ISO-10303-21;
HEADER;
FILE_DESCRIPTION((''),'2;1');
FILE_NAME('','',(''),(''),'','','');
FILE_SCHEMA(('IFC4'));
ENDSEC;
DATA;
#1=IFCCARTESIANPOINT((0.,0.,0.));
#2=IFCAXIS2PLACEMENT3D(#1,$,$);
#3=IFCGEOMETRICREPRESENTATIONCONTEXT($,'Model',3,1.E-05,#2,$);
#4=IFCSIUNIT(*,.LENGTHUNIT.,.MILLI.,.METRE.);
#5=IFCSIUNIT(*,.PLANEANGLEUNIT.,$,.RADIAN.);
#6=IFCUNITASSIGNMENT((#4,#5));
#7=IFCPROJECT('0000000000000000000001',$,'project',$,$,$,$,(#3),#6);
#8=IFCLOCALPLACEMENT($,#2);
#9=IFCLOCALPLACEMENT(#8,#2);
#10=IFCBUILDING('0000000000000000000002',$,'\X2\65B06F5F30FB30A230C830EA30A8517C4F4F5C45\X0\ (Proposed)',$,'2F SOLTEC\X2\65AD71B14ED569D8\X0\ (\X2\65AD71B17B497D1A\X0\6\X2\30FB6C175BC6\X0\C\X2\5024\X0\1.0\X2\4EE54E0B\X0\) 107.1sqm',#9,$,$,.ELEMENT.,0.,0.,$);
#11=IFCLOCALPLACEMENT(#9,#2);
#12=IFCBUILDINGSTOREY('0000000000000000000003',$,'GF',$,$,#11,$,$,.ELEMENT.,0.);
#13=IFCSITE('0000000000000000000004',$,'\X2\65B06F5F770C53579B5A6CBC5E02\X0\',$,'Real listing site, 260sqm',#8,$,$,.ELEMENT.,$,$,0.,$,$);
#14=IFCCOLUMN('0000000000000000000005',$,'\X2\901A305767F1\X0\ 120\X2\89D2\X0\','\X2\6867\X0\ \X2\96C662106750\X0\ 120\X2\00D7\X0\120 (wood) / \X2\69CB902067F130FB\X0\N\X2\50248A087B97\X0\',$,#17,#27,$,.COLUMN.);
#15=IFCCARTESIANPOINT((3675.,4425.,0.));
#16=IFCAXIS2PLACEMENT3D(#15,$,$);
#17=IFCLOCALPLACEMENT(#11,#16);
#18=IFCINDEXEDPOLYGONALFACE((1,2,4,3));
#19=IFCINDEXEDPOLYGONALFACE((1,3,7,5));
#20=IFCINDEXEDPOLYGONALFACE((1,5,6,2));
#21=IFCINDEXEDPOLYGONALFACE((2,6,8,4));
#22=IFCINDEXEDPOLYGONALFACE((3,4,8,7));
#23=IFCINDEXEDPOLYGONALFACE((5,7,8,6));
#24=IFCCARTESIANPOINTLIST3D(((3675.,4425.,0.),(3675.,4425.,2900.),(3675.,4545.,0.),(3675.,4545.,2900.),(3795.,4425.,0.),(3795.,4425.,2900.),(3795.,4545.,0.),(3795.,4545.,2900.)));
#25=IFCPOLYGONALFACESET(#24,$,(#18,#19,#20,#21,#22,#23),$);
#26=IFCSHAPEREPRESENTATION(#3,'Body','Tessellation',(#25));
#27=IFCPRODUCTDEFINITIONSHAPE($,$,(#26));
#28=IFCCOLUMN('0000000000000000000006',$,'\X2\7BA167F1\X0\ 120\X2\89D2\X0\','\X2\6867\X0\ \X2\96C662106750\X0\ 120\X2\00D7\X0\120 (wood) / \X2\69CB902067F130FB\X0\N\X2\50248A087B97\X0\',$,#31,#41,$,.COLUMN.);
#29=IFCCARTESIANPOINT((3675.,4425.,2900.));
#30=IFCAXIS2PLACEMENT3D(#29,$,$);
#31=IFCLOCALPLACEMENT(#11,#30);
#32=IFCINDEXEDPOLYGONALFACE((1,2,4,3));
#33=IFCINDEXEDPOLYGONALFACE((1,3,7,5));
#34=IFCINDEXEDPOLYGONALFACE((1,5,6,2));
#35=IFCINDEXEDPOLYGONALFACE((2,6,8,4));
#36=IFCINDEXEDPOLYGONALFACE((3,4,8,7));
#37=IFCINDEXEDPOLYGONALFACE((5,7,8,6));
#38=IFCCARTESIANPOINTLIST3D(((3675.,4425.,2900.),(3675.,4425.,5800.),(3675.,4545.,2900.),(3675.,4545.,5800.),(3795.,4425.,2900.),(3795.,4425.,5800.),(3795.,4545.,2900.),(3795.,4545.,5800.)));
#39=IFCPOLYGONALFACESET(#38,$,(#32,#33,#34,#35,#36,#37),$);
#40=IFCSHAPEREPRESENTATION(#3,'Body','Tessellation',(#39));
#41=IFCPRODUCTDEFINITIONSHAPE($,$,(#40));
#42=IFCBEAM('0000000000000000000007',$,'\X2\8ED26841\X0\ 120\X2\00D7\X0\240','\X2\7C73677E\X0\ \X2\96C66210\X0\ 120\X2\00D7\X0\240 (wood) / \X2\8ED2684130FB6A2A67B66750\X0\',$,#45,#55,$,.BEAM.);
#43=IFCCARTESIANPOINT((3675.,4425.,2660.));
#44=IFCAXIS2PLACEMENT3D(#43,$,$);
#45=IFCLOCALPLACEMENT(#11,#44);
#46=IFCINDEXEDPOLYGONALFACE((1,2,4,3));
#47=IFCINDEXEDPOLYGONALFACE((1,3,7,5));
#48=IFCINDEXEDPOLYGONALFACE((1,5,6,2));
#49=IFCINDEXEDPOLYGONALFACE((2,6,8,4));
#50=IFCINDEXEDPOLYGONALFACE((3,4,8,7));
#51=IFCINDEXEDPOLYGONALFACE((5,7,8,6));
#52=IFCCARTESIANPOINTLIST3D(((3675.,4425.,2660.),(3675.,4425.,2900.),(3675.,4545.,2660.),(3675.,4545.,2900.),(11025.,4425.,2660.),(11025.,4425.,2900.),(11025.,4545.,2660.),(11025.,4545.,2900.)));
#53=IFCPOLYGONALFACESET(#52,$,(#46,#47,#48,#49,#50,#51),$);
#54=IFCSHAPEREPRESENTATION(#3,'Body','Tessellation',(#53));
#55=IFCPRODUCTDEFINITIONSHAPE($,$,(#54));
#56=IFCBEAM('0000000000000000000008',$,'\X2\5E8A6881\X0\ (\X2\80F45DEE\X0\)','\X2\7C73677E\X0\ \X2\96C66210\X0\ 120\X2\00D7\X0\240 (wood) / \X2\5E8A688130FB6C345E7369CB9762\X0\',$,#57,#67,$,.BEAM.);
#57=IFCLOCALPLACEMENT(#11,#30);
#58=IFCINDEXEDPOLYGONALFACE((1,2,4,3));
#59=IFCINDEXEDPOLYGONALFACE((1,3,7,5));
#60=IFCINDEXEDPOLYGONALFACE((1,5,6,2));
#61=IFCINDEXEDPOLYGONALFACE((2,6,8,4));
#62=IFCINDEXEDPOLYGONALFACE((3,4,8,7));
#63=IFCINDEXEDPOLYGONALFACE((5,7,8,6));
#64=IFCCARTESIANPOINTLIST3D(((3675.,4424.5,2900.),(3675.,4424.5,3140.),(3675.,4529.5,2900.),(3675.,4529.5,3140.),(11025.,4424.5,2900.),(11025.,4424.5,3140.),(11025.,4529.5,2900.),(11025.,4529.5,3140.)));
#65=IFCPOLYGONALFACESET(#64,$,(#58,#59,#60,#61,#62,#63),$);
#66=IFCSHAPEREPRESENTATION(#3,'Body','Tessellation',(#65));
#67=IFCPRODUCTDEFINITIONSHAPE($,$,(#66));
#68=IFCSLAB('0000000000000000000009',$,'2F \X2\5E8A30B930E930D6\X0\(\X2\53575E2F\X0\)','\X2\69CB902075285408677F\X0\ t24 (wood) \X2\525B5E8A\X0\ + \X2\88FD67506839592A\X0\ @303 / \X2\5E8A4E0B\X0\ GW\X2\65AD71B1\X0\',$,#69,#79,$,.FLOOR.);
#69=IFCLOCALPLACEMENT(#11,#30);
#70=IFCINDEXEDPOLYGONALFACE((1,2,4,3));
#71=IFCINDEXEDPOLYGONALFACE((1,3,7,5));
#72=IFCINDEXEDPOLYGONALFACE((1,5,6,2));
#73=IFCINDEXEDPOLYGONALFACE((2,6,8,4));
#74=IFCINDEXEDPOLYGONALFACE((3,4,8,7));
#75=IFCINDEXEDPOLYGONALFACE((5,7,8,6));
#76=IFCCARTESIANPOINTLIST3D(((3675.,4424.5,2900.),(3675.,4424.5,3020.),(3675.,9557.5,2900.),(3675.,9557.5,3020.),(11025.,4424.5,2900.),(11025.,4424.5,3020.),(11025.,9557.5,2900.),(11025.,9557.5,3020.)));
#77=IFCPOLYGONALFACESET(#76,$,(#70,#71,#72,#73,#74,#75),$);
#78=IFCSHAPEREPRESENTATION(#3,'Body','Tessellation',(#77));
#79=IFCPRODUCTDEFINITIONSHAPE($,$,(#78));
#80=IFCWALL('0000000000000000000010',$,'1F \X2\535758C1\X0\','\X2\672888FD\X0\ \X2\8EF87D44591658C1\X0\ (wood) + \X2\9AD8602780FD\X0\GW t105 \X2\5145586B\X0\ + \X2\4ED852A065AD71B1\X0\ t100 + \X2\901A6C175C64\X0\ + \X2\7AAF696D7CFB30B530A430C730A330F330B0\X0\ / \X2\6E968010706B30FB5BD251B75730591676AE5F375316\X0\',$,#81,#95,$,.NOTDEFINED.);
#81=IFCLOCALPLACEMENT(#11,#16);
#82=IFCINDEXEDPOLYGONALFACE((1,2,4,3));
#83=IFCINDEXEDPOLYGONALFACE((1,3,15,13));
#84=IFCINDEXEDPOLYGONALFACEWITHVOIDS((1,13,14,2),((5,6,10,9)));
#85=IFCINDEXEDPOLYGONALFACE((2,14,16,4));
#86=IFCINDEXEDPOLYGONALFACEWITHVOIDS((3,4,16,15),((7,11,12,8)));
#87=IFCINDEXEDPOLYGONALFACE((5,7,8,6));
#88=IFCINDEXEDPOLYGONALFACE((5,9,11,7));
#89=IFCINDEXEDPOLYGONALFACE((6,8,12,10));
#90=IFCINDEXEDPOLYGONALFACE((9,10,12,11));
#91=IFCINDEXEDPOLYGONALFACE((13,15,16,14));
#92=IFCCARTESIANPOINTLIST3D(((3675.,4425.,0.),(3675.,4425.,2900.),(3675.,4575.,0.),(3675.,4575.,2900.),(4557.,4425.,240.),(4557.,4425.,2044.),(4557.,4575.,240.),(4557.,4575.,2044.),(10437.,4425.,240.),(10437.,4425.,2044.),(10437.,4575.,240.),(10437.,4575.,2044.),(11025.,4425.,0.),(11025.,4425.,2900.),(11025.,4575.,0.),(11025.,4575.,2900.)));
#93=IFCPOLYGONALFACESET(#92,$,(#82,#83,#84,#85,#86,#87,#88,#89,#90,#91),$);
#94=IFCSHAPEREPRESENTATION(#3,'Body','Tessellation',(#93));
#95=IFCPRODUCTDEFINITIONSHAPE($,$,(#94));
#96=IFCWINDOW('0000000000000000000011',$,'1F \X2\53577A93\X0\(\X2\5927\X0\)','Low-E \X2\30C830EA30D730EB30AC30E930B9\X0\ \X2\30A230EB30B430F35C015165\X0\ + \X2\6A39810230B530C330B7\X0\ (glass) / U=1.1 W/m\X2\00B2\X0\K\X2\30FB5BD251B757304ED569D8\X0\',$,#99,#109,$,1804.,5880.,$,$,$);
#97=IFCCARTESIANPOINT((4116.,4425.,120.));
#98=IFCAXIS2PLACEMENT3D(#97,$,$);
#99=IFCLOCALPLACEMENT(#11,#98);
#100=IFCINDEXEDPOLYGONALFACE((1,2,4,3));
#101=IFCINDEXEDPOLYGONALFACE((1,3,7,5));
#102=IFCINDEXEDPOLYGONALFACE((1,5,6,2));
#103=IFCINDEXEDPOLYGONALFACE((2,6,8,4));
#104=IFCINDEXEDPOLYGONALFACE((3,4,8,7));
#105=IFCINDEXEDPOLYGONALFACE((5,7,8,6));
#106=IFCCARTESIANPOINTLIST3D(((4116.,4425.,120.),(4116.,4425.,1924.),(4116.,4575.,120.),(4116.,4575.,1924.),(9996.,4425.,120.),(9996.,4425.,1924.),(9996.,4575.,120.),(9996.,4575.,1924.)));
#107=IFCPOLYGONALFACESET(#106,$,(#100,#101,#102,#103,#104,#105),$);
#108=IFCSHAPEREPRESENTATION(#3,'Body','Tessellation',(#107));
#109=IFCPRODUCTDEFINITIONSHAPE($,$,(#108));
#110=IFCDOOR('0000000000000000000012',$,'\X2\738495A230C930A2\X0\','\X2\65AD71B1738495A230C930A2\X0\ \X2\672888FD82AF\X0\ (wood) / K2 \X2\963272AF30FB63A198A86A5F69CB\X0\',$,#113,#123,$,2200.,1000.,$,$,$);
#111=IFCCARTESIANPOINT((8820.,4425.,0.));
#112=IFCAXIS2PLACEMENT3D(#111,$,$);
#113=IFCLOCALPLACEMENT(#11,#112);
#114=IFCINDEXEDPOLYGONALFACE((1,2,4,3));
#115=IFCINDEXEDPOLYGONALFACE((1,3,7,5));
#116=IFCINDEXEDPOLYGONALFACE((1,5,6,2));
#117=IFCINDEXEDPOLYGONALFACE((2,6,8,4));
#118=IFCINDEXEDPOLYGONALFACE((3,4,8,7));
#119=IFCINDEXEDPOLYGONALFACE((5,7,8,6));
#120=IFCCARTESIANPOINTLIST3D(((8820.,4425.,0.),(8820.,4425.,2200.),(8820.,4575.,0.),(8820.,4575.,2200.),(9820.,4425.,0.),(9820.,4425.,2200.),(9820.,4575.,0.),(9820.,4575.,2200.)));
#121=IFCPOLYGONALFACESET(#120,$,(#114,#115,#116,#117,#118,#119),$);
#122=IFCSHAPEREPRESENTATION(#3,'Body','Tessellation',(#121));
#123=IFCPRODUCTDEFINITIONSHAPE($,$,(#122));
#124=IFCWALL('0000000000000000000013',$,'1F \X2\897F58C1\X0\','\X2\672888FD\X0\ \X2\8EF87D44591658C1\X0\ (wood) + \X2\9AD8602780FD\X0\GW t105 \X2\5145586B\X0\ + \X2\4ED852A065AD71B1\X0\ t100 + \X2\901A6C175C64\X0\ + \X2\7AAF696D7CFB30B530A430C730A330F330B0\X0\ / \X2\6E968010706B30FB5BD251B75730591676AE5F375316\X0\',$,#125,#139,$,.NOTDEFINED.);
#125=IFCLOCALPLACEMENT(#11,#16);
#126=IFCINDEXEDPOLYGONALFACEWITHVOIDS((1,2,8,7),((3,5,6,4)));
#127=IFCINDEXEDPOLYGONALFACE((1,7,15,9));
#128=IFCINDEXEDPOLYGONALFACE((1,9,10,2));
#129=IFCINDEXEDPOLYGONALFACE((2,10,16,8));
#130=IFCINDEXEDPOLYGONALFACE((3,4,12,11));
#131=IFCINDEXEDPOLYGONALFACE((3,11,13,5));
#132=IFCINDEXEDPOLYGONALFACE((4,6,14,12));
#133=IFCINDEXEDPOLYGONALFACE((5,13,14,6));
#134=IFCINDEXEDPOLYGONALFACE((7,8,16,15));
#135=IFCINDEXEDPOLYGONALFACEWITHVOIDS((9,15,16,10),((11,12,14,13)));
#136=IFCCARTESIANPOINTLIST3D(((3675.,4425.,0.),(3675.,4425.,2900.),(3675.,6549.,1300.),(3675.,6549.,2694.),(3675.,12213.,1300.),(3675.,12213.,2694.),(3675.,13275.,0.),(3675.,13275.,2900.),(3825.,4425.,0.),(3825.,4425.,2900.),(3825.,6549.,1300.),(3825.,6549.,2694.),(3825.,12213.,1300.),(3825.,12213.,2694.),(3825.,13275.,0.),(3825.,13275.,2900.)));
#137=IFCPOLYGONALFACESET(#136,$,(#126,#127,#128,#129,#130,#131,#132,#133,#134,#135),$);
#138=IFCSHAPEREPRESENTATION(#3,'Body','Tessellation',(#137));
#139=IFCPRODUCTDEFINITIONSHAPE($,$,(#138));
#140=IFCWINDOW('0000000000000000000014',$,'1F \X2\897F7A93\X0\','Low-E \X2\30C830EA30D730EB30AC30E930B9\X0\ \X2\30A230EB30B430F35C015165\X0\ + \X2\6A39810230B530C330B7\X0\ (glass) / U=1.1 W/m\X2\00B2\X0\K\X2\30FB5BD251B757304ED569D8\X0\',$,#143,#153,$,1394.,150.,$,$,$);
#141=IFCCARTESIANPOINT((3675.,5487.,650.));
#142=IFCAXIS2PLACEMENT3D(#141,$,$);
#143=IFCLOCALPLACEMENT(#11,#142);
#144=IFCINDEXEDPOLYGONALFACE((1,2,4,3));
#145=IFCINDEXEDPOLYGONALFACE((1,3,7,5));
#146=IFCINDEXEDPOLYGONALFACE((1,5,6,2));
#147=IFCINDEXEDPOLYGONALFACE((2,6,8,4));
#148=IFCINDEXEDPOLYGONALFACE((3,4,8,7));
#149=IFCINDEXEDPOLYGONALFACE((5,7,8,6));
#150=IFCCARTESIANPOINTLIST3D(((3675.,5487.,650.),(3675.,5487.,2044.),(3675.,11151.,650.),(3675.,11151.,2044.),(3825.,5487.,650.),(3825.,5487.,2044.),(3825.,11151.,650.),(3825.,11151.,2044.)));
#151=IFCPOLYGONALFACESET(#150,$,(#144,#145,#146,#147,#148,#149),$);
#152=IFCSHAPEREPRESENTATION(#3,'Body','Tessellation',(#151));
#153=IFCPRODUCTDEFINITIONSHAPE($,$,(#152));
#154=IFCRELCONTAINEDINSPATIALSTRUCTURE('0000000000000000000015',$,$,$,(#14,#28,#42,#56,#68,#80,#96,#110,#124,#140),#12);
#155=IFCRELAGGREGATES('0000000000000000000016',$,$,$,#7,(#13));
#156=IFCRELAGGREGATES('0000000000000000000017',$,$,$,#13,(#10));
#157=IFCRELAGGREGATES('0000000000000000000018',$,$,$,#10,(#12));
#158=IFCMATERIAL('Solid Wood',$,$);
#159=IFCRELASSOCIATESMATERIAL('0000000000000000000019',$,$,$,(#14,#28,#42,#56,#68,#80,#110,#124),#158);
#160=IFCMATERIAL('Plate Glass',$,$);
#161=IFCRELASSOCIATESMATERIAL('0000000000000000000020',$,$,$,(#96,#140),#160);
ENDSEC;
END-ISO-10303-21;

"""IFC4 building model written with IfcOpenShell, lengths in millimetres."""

from ifc_helpers import new_model, si_unit, frame, frame_2d, origin, place, context, project, spatial, rectangle, extrude, material, element, fill, save


model = new_model("IFC4")

# Units and contexts
model_context = context("Model", 3, precision=1e-05, world=origin())
ifc_project = project(units=[si_unit("LENGTHUNIT", "METRE", prefix="MILLI"), si_unit("PLANEANGLEUNIT", "RADIAN")], contexts=[model_context])

# Site, building, storey
site_placement = place(None, origin())
site = spatial("IfcSite", under=ifc_project, at=site_placement, Name="新潟県南魚沼市", ObjectType="Real listing site, 260sqm", CompositionType="ELEMENT", RefElevation=0.0)
building_placement = place(site_placement, origin())
building = spatial("IfcBuilding", under=site, at=building_placement, Name="新潟・アトリエ兼住居 (Proposed)", ObjectType="2F SOLTEC断熱仕様 (断熱等級6・気密C値1.0以下) 107.1sqm", CompositionType="ELEMENT", ElevationOfRefHeight=0.0, ElevationOfTerrain=0.0)
storey_placement = place(building_placement, origin())
storey = spatial("IfcBuildingStorey", under=building, at=storey_placement, Name="GF", CompositionType="ELEMENT", Elevation=0.0)

# Columns
ifc_material_1 = material(Name="Solid Wood")
column_1_placement = place(storey_placement, frame((3675.0, 4425.0, 0.0)))
element("IfcColumn", 1, at=column_1_placement, inside=storey, material=ifc_material_1, Name="通し柱 120角", Description="桧 集成材 120×120 (wood) / 構造柱・N値計算", PredefinedType="COLUMN", context=model_context, shape_type="SweptSolid", body=[
    extrude(rectangle(XDim=120.0, YDim=120.0, at=frame_2d((60.0, 60.0))), frame((3675.0, 4425.0, 0.0)), (0.0, 0.0, 1.0), 2900.0),
])
column_2_placement = place(storey_placement, frame((3675.0, 4425.0, 2900.0)))
element("IfcColumn", 2, at=column_2_placement, inside=storey, material=ifc_material_1, Name="管柱 120角", Description="桧 集成材 120×120 (wood) / 構造柱・N値計算", PredefinedType="COLUMN", context=model_context, shape_type="SweptSolid", body=[
    extrude(rectangle(XDim=120.0, YDim=120.0, at=frame_2d((60.0, 60.0))), frame((3675.0, 4425.0, 2900.0)), (0.0, 0.0, 1.0), 2900.0),
])

# Beams
beam_1_placement = place(storey_placement, frame((3675.0, 4425.0, 2660.0)))
element("IfcBeam", 3, at=beam_1_placement, inside=storey, material=ifc_material_1, Name="軒桁 120×240", Description="米松 集成 120×240 (wood) / 軒桁・横架材", PredefinedType="BEAM", context=model_context, shape_type="SweptSolid", body=[
    extrude(rectangle(XDim=7350.0, YDim=120.0, at=frame_2d((3675.0, 60.0))), frame((3675.0, 4425.0, 2660.0)), (0.0, 0.0, 1.0), 240.0),
])
beam_2_placement = place(storey_placement, frame((3675.0, 4425.0, 2900.0)))
element("IfcBeam", 4, at=beam_2_placement, inside=storey, material=ifc_material_1, Name="床梁 (胴差)", Description="米松 集成 120×240 (wood) / 床梁・水平構面", PredefinedType="BEAM", context=model_context, shape_type="SweptSolid", body=[
    extrude(rectangle(XDim=7350.0, YDim=105.0, at=frame_2d((3675.0, 52.0))), frame((3675.0, 4425.0, 2900.0)), (0.0, 0.0, 1.0), 240.0),
])

# Slab
slab_1_placement = place(storey_placement, frame((3675.0, 4425.0, 2900.0)))
element("IfcSlab", 5, at=slab_1_placement, inside=storey, material=ifc_material_1, Name="2F 床スラブ(南帯)", Description="構造用合板 t24 (wood) 剛床 + 製材根太 @303 / 床下 GW断熱", PredefinedType="FLOOR", context=model_context, shape_type="SweptSolid", body=[
    extrude(rectangle(XDim=7350.0, YDim=5133.0, at=frame_2d((3675.0, 2566.0))), frame((3675.0, 4425.0, 2900.0)), (0.0, 0.0, 1.0), 120.0),
])

# Wall, openings, window, door
wall_1_placement = place(storey_placement, frame((3675.0, 4425.0, 0.0)))
wall_1 = element("IfcWall", 6, at=wall_1_placement, inside=storey, material=ifc_material_1, Name="1F 南壁", Description="木製 軸組外壁 (wood) + 高性能GW t105 充填 + 付加断熱 t100 + 通気層 + 窯業系サイディング / 準耐火・寒冷地外皮強化", PredefinedType="NOTDEFINED", context=model_context, shape_type="SweptSolid", body=[
    extrude(rectangle(XDim=7350.0, YDim=150.0, at=frame_2d((3675.0, 75.0))), frame((3675.0, 4425.0, 0.0)), (0.0, 0.0, 1.0), 2900.0),
])
opening_1_placement = place(storey_placement, frame((4116.0, 4425.0, 120.0)))
opening_1 = element("IfcOpeningElement", 7, at=opening_1_placement, cuts=wall_1, PredefinedType="NOTDEFINED", context=model_context, shape_type="SweptSolid", body=[
    extrude(rectangle(XDim=5880.0, YDim=150.0, at=frame_2d((2940.0, 75.0))), frame((4116.0, 4425.0, 120.0)), (0.0, 0.0, 1.0), 1804.0),
])
opening_2_placement = place(storey_placement, frame((8820.0, 4425.0, 0.0)))
opening_2 = element("IfcOpeningElement", 8, at=opening_2_placement, cuts=wall_1, PredefinedType="NOTDEFINED", context=model_context, shape_type="SweptSolid", body=[
    extrude(rectangle(XDim=1000.0, YDim=150.0, at=frame_2d((500.0, 75.0))), frame((8820.0, 4425.0, 0.0)), (0.0, 0.0, 1.0), 2200.0),
])
ifc_material_2 = material(Name="Plate Glass")
window_1_placement = place(storey_placement, frame((4116.0, 4425.0, 120.0)))
window_1 = element("IfcWindow", 9, at=window_1_placement, inside=storey, material=ifc_material_2, Name="1F 南窓(大)", Description="Low-E トリプルガラス アルゴン封入 + 樹脂サッシ (glass) / U=1.1 W/m²K・寒冷地仕様", OverallHeight=1804.0, OverallWidth=5880.0, context=model_context, shape_type="SweptSolid", body=[
    extrude(rectangle(XDim=5880.0, YDim=150.0, at=frame_2d((2940.0, 75.0))), frame((4116.0, 4425.0, 120.0)), (0.0, 0.0, 1.0), 1804.0),
])
fill(opening_1, window_1)
door_placement = place(storey_placement, frame((8820.0, 4425.0, 0.0)))
door = element("IfcDoor", 10, at=door_placement, inside=storey, material=ifc_material_1, Name="玄関ドア", Description="断熱玄関ドア 木製芯 (wood) / K2 防犯・採風機構", OverallHeight=2200.0, OverallWidth=1000.0, context=model_context, shape_type="SweptSolid", body=[
    extrude(rectangle(XDim=1000.0, YDim=150.0, at=frame_2d((500.0, 75.0))), frame((8820.0, 4425.0, 0.0)), (0.0, 0.0, 1.0), 2200.0),
])
fill(opening_2, door)

# Wall, opening, window
wall_2_placement = place(storey_placement, frame((3675.0, 4425.0, 0.0)))
wall_2 = element("IfcWall", 11, at=wall_2_placement, inside=storey, material=ifc_material_1, Name="1F 西壁", Description="木製 軸組外壁 (wood) + 高性能GW t105 充填 + 付加断熱 t100 + 通気層 + 窯業系サイディング / 準耐火・寒冷地外皮強化", PredefinedType="NOTDEFINED", context=model_context, shape_type="SweptSolid", body=[
    extrude(rectangle(XDim=150.0, YDim=8850.0, at=frame_2d((75.0, 4425.0))), frame((3675.0, 4425.0, 0.0)), (0.0, 0.0, 1.0), 2900.0),
])
opening_3_placement = place(storey_placement, frame((3675.0, 5487.0, 650.0)))
opening_3 = element("IfcOpeningElement", 12, at=opening_3_placement, cuts=wall_2, PredefinedType="NOTDEFINED", context=model_context, shape_type="SweptSolid", body=[
    extrude(rectangle(XDim=150.0, YDim=5664.0, at=frame_2d((75.0, 2832.0))), frame((3675.0, 5487.0, 650.0)), (0.0, 0.0, 1.0), 1394.0),
])
window_2_placement = place(storey_placement, frame((3675.0, 5487.0, 650.0)))
window_2 = element("IfcWindow", 13, at=window_2_placement, inside=storey, material=ifc_material_2, Name="1F 西窓", Description="Low-E トリプルガラス アルゴン封入 + 樹脂サッシ (glass) / U=1.1 W/m²K・寒冷地仕様", OverallHeight=1394.0, OverallWidth=150.0, context=model_context, shape_type="SweptSolid", body=[
    extrude(rectangle(XDim=150.0, YDim=5664.0, at=frame_2d((75.0, 2832.0))), frame((3675.0, 5487.0, 650.0)), (0.0, 0.0, 1.0), 1394.0),
])
fill(opening_3, window_2)

save(model, "model.ifc")
